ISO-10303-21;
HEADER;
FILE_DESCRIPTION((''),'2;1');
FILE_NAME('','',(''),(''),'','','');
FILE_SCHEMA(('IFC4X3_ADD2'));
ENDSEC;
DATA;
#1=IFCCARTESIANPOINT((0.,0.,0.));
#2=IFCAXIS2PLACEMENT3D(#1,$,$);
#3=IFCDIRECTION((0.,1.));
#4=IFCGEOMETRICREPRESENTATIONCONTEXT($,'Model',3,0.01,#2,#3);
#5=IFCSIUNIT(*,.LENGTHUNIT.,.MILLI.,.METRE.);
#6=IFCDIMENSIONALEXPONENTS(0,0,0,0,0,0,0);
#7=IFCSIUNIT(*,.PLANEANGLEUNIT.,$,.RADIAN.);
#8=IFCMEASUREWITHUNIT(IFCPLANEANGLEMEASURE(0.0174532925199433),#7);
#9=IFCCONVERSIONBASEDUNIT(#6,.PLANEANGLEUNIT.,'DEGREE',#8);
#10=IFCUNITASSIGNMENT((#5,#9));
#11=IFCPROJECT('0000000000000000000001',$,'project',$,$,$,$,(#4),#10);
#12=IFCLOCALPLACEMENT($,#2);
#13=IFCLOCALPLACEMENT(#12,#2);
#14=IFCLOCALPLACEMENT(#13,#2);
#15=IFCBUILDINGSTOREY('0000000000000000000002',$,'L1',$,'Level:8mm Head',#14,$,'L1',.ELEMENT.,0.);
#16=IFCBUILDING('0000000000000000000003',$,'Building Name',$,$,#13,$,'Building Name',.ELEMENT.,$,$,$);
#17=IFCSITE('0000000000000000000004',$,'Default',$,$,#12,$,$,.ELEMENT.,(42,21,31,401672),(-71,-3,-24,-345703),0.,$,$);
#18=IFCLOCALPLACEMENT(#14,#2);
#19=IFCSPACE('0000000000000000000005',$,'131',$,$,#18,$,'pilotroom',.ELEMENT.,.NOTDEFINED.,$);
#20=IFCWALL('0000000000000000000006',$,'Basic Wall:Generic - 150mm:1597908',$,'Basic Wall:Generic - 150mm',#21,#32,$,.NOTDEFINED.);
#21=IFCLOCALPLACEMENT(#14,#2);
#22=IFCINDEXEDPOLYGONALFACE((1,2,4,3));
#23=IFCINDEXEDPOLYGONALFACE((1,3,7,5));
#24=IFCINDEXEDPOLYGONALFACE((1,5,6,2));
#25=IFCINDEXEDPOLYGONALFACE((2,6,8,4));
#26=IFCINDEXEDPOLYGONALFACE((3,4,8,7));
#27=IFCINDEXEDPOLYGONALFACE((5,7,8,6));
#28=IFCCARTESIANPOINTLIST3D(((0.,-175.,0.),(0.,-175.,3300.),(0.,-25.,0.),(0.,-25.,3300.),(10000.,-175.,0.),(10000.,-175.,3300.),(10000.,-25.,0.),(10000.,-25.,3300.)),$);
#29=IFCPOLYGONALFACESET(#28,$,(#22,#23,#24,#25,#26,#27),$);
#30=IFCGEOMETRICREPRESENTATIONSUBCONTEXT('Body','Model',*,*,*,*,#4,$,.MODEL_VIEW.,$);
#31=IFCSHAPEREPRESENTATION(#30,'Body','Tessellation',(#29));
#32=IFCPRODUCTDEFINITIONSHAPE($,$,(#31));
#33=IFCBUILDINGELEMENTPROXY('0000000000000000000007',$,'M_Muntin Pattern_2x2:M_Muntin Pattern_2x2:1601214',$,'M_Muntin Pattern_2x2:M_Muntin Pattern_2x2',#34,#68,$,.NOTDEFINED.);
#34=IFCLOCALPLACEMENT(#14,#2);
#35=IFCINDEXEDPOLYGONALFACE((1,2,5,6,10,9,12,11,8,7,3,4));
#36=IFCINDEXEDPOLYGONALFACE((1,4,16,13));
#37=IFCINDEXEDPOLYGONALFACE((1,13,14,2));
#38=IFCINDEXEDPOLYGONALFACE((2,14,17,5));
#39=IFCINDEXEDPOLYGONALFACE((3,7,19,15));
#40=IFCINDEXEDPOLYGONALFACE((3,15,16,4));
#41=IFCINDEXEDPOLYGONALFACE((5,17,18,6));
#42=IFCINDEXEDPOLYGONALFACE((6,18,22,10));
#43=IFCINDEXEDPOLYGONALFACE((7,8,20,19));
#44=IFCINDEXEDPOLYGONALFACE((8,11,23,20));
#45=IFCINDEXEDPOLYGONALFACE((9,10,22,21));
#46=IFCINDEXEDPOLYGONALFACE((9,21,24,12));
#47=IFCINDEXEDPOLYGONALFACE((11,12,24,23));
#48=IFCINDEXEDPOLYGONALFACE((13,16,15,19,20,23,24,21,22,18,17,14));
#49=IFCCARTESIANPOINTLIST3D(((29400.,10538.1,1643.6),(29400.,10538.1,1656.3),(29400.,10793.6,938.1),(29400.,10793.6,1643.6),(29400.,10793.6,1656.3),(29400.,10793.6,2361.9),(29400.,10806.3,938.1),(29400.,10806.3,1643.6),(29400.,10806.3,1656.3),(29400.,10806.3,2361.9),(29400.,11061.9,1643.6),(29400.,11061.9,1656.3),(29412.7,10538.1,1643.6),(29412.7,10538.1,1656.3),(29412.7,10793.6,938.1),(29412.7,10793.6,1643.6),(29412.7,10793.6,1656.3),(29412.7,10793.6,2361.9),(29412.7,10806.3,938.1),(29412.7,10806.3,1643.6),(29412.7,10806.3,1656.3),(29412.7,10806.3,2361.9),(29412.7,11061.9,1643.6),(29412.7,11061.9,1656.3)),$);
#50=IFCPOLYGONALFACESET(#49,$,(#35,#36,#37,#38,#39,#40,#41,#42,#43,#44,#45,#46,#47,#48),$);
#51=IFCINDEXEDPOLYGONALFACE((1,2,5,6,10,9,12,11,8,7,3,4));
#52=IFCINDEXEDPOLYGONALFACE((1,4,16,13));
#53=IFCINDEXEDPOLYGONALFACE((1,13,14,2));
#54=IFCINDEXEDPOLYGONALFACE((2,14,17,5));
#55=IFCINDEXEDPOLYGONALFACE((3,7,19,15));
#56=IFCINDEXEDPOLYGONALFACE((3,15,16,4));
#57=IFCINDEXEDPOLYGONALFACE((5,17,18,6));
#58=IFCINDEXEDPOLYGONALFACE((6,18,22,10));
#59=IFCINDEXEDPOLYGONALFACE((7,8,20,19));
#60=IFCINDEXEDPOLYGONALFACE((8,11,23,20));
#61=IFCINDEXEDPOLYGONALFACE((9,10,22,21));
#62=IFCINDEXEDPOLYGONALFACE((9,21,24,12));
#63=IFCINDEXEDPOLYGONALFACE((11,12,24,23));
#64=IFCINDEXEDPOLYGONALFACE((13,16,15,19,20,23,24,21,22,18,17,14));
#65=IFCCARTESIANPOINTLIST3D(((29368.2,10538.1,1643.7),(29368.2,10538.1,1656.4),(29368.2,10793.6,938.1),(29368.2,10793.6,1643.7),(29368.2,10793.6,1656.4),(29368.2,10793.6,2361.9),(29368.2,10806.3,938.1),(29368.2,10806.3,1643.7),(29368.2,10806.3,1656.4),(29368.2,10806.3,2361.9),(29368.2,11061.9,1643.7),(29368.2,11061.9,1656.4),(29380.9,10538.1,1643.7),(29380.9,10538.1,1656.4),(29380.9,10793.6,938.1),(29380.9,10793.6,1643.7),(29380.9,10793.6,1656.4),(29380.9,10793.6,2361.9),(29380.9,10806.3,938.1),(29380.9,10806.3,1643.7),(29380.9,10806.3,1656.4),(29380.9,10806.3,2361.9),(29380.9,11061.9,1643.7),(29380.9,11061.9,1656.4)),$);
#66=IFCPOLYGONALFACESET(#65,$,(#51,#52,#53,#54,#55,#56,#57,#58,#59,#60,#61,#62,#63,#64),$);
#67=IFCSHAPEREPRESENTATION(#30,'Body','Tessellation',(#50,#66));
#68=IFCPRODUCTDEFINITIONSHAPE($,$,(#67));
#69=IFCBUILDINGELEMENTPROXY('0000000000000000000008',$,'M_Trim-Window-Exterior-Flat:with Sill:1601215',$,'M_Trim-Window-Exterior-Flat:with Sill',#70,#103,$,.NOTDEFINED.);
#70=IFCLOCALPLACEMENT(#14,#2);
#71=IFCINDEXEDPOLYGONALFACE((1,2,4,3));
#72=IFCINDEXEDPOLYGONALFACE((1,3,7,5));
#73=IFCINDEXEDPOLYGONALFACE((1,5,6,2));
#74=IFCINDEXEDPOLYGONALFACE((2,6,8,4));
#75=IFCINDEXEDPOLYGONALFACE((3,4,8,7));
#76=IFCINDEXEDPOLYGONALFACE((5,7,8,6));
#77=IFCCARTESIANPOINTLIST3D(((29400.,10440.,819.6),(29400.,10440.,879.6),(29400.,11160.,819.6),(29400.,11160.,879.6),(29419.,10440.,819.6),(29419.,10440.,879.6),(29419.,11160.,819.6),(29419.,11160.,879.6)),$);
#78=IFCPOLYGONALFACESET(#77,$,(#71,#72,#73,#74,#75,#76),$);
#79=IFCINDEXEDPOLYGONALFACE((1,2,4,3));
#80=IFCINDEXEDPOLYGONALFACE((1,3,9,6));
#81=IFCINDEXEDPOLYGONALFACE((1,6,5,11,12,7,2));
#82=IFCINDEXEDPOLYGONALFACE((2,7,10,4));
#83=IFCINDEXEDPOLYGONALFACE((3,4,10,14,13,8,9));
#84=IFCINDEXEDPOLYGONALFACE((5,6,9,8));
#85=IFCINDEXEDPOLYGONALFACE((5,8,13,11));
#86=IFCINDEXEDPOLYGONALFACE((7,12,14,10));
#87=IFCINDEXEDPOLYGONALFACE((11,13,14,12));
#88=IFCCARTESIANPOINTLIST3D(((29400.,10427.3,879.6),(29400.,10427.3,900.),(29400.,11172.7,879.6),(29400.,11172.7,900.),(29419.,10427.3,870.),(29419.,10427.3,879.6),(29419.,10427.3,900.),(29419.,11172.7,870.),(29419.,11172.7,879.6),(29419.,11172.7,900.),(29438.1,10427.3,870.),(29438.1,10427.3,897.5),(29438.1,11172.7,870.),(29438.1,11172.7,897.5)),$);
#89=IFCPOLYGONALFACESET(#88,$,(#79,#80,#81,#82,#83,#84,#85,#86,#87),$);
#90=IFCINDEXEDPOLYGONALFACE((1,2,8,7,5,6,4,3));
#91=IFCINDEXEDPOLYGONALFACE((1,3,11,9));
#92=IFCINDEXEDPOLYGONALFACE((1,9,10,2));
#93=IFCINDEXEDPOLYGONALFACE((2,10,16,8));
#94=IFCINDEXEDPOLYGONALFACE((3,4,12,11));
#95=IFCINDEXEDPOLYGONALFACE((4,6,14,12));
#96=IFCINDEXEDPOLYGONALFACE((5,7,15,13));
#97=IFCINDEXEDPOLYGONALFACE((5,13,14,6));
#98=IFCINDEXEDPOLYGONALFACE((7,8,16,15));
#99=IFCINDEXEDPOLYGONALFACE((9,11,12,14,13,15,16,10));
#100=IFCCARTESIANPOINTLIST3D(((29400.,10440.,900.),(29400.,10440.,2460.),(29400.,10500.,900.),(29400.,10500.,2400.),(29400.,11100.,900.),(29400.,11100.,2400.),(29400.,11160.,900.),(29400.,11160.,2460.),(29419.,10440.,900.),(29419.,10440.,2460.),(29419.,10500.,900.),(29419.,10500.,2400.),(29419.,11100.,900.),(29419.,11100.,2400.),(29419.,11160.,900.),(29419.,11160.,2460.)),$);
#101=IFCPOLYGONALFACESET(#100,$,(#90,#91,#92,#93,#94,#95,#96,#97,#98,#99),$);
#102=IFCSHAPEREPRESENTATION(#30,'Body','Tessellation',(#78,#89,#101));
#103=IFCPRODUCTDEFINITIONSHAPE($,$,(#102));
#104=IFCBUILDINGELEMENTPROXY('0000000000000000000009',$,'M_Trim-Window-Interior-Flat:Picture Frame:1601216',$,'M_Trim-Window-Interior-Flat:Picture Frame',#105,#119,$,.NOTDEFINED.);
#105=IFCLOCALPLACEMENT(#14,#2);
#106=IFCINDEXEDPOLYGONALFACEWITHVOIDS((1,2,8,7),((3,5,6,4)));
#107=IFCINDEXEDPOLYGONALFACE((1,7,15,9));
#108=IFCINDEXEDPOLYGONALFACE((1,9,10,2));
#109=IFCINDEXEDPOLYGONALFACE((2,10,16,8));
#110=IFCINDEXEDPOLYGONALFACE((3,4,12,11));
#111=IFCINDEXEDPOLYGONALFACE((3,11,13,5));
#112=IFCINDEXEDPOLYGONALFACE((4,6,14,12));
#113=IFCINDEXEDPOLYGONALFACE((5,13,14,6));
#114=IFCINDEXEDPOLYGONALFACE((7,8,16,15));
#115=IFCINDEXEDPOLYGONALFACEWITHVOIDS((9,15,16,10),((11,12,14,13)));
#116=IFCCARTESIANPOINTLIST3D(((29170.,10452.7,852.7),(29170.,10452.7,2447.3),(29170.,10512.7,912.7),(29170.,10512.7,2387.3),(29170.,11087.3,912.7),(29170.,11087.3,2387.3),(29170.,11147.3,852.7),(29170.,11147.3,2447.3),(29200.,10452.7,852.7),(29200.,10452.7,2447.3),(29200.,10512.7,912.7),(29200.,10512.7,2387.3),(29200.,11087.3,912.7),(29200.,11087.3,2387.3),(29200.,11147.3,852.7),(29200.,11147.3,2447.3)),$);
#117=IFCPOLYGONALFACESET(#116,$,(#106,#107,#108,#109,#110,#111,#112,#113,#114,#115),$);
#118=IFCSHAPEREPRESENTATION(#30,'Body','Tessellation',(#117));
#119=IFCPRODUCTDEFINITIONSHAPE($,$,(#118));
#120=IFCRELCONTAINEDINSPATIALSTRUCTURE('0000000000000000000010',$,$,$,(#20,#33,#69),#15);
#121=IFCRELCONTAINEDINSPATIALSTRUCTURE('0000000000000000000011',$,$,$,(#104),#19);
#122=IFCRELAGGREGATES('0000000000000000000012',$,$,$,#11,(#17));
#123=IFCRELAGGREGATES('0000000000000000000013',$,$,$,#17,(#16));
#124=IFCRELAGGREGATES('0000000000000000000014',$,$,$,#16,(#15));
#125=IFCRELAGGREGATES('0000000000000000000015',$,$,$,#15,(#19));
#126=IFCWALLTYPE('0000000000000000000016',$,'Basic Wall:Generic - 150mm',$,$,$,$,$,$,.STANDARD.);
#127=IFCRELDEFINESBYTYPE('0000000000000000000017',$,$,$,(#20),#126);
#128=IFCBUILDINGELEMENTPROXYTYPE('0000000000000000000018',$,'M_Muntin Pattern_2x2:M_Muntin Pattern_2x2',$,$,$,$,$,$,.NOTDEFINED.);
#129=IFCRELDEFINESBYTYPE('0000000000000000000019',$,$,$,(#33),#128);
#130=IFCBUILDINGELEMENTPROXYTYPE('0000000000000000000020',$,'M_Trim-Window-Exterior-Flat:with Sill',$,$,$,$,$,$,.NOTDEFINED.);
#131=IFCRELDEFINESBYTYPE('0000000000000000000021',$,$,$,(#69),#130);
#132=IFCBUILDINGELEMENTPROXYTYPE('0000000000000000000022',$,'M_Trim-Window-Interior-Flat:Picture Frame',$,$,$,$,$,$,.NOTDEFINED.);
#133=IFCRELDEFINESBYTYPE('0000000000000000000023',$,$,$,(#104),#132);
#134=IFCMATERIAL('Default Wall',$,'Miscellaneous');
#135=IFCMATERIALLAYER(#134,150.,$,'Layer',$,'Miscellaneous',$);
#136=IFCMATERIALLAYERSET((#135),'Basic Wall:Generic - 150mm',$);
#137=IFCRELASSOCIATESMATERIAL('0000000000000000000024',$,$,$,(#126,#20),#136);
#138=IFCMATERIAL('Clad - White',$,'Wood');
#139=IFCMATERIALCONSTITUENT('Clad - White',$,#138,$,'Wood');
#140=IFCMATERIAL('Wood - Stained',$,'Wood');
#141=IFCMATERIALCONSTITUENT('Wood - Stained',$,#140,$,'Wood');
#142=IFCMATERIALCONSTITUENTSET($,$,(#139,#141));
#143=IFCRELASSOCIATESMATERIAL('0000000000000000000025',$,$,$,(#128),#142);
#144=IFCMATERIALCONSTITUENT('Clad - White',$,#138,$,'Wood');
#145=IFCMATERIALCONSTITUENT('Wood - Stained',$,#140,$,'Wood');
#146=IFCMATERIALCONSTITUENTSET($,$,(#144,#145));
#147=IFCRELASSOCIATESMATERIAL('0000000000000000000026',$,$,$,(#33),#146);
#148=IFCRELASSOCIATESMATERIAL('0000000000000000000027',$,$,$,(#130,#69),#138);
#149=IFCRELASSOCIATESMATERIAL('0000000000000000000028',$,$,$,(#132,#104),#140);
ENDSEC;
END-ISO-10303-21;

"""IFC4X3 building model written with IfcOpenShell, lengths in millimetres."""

from ifc_helpers import new_model, entity, si_unit, converted_unit, direction, frame, frame_2d, origin, place, context, subcontext, project, spatial, polyline, rectangle, outline, extrude, source, transform, mapped, material, layer, layer_set, constituent, constituent_set, type_object, type_shapes, element, save


model = new_model("IFC4X3")

# Units and contexts
model_context = context("Model", 3, precision=0.01, world=origin(), true_north=direction((0.0, 1.0)))
body_context = subcontext(model_context, "Body", "Model", "MODEL_VIEW")
ifc_project = project(units=[si_unit("LENGTHUNIT", "METRE", prefix="MILLI"), converted_unit("PLANEANGLEUNIT", "DEGREE", entity("IfcPlaneAngleMeasure", 0.0174532925199433), si_unit("PLANEANGLEUNIT", "RADIAN"), dimensions=[0, 0, 0, 0, 0, 0, 0])], contexts=[model_context])

# Site, building, storey
site_placement = place(None, origin())
site = spatial("IfcSite", under=ifc_project, at=site_placement, Name="Default", CompositionType="ELEMENT", RefLatitude=(42, 21, 31, 401672), RefLongitude=(-71, -3, -24, -345703), RefElevation=0.0)
building_placement = place(site_placement, origin())
building = spatial("IfcBuilding", under=site, at=building_placement, Name="Building Name", LongName="Building Name", CompositionType="ELEMENT")
storey_placement = place(building_placement, origin())
storey = spatial("IfcBuildingStorey", under=building, at=storey_placement, Name="L1", ObjectType="Level:8mm Head", LongName="L1", CompositionType="ELEMENT", Elevation=0.0)

# Shared definitions
ifc_material_1 = material(Name="Default Wall", Category="Miscellaneous")

# Wall
ifc_layer_1 = layer(ifc_material_1, 150.0, Name="Layer", Category="Miscellaneous")
ifc_layer_set_1 = layer_set([ifc_layer_1], Name="Basic Wall:Generic - 150mm")
wall_type_1 = type_object("IfcWallType", Name="Basic Wall:Generic - 150mm", PredefinedType="STANDARD", material=ifc_layer_set_1)
wall_1_placement = place(storey_placement, frame((0.0, -100.0, 0.0)))
element("IfcWall", 1, at=wall_1_placement, inside=storey, type_object=wall_type_1, material=ifc_layer_set_1, Name="Basic Wall:Generic - 150mm:1597908", ObjectType="Basic Wall:Generic - 150mm", PredefinedType="NOTDEFINED", context=body_context, shape_type="SweptSolid", body=[
    extrude(rectangle(XDim=10000.0, YDim=150.0, at=frame_2d((5000.0, 0.0), x_axis=(-1.0, 0.0))), origin(), (0.0, 0.0, 1.0), 3300.0),
])

# Building element proxies
ifc_material_2 = material(Name="Clad - White", Category="Wood")
ifc_constituent_1 = constituent(ifc_material_2, Name="Clad - White", Category="Wood")
ifc_material_3 = material(Name="Wood - Stained", Category="Wood")
ifc_constituent_2 = constituent(ifc_material_3, Name="Wood - Stained", Category="Wood")
ifc_constituent_set_1 = constituent_set(constituents=[ifc_constituent_1, ifc_constituent_2])
ifc_constituent_3 = constituent(ifc_material_2, Name="Clad - White", Category="Wood")
ifc_constituent_4 = constituent(ifc_material_3, Name="Wood - Stained", Category="Wood")
ifc_constituent_set_2 = constituent_set(constituents=[ifc_constituent_3, ifc_constituent_4])
building_element_proxy_type_1 = type_object("IfcBuildingElementProxyType", Name="M_Muntin Pattern_2x2:M_Muntin Pattern_2x2", PredefinedType="NOTDEFINED", material=ifc_constituent_set_2)
shared_shape_1 = source(origin(), body_context, "Body", "SweptSolid", [
    extrude(outline(polyline([(6.4, -6.4), (711.9, -6.4), (711.9, 6.3), (6.4, 6.3), (6.4, 261.9), (-6.3, 261.9), (-6.3, 6.3), (-711.9, 6.3), (-711.9, -6.4), (-6.3, -6.4), (-6.3, -261.9), (6.4, -261.9), (6.4, -6.4)])), frame((0.0, -22.2, 711.9), z_axis=(0.0, 1.0, 0.0), x_axis=(0.0, 0.0, 1.0)), (0.0, 0.0, 1.0), 12.7),
    extrude(outline(polyline([(6.4, -6.4), (711.9, -6.4), (711.9, 6.3), (6.4, 6.3), (6.4, 261.9), (-6.3, 261.9), (-6.3, 6.3), (-711.9, 6.3), (-711.9, -6.4), (-6.3, -6.4), (-6.3, -261.9), (6.4, -261.9), (6.4, -6.4)])), frame((0.0, 9.5, 711.9), z_axis=(0.0, 1.0, 0.0), x_axis=(0.0, 0.0, 1.0)), (0.0, 0.0, 1.0), 12.7),
])
type_shapes(building_element_proxy_type_1, [shared_shape_1])
proxy_1_placement = place(storey_placement, frame((29390.5, 10800.0, 938.1), z_axis=(0.0, 0.0, 1.0), x_axis=(0.0, 1.0, 0.0)))
element("IfcBuildingElementProxy", 2, at=proxy_1_placement, inside=storey, type_object=building_element_proxy_type_1, material=ifc_constituent_set_1, Name="M_Muntin Pattern_2x2:M_Muntin Pattern_2x2:1601214", ObjectType="M_Muntin Pattern_2x2:M_Muntin Pattern_2x2", PredefinedType="NOTDEFINED", context=body_context, shape_type="MappedRepresentation", body=[
    mapped(shared_shape_1, transform((0.0, 0.0, 0.0), scale=1.0)),
])
building_element_proxy_type_2 = type_object("IfcBuildingElementProxyType", Name="M_Trim-Window-Exterior-Flat:with Sill", PredefinedType="NOTDEFINED", material=ifc_material_2)
shared_shape_2 = source(origin(), body_context, "Body", "SweptSolid", [
    extrude(rectangle(XDim=720.0, YDim=60.0, at=frame_2d((0.0, 0.0), x_axis=(1.0, 0.0))), frame((0.0, -1550.4, 0.0), z_axis=(0.0, 0.0, 1.0), x_axis=(-1.0, 0.0, 0.0)), (0.0, 0.0, 1.0), 19.1),
    extrude(outline(polyline([(-19.0, -15.2), (0.0, -15.2), (0.0, -5.7), (19.0, -5.7), (19.0, 14.8), (0.0, 14.8), (-19.0, 12.3), (-19.0, -15.2)])), frame((-372.7, -1514.8, 19.0), z_axis=(1.0, 0.0, 0.0), x_axis=(0.0, 0.0, -1.0)), (0.0, 0.0, 1.0), 745.4),
    extrude(outline(polyline([(-795.0, -360.0), (765.0, -360.0), (765.0, -300.0), (-735.0, -300.0), (-735.0, 300.0), (765.0, 300.0), (765.0, 360.0), (-795.0, 360.0), (-795.0, -360.0)])), frame((0.0, -735.0, 0.0), z_axis=(0.0, 0.0, 1.0), x_axis=(0.0, -1.0, 0.0)), (0.0, 0.0, 1.0), 19.1),
])
type_shapes(building_element_proxy_type_2, [shared_shape_2])
proxy_2_placement = place(storey_placement, frame((29400.0, 10800.0, 2400.0), z_axis=(1.0, 0.0, 0.0), x_axis=(0.0, 1.0, 0.0)))
element("IfcBuildingElementProxy", 3, at=proxy_2_placement, inside=storey, type_object=building_element_proxy_type_2, material=ifc_material_2, Name="M_Trim-Window-Exterior-Flat:with Sill:1601215", ObjectType="M_Trim-Window-Exterior-Flat:with Sill", PredefinedType="NOTDEFINED", context=body_context, shape_type="MappedRepresentation", body=[
    mapped(shared_shape_2, transform((0.0, 0.0, 0.0), scale=1.0)),
])

# Shared definitions
space_placement = place(storey_placement, origin())
space = spatial("IfcSpace", under=storey, at=space_placement, Name="131", LongName="pilotroom", CompositionType="ELEMENT", PredefinedType="NOTDEFINED")

# Building element proxy
building_element_proxy_type_3 = type_object("IfcBuildingElementProxyType", Name="M_Trim-Window-Interior-Flat:Picture Frame", PredefinedType="NOTDEFINED", material=ifc_material_3)
shared_shape_3 = source(origin(), body_context, "Body", "SweptSolid", [
    extrude(outline(polyline([(-347.3, -797.3), (347.3, -797.3), (347.3, 797.3), (-347.3, 797.3), (-347.3, -797.3)]), holes=[polyline([(-287.3, -737.3), (-287.3, 737.3), (287.3, 737.3), (287.3, -737.3), (-287.3, -737.3)])]), frame((0.0, -750.0, 0.0), z_axis=(0.0, 0.0, 1.0), x_axis=(-1.0, 0.0, 0.0)), (0.0, 0.0, 1.0), 30.0),
])
type_shapes(building_element_proxy_type_3, [shared_shape_3])
proxy_3_placement = place(space_placement, frame((29200.0, 10800.0, 2400.0), z_axis=(-1.0, 0.0, 0.0), x_axis=(0.0, -1.0, 0.0)))
element("IfcBuildingElementProxy", 4, at=proxy_3_placement, inside=space, type_object=building_element_proxy_type_3, material=ifc_material_3, Name="M_Trim-Window-Interior-Flat:Picture Frame:1601216", ObjectType="M_Trim-Window-Interior-Flat:Picture Frame", PredefinedType="NOTDEFINED", context=body_context, shape_type="MappedRepresentation", body=[
    mapped(shared_shape_3, transform((0.0, 0.0, 0.0), scale=1.0)),
])

save(model, "model.ifc")
